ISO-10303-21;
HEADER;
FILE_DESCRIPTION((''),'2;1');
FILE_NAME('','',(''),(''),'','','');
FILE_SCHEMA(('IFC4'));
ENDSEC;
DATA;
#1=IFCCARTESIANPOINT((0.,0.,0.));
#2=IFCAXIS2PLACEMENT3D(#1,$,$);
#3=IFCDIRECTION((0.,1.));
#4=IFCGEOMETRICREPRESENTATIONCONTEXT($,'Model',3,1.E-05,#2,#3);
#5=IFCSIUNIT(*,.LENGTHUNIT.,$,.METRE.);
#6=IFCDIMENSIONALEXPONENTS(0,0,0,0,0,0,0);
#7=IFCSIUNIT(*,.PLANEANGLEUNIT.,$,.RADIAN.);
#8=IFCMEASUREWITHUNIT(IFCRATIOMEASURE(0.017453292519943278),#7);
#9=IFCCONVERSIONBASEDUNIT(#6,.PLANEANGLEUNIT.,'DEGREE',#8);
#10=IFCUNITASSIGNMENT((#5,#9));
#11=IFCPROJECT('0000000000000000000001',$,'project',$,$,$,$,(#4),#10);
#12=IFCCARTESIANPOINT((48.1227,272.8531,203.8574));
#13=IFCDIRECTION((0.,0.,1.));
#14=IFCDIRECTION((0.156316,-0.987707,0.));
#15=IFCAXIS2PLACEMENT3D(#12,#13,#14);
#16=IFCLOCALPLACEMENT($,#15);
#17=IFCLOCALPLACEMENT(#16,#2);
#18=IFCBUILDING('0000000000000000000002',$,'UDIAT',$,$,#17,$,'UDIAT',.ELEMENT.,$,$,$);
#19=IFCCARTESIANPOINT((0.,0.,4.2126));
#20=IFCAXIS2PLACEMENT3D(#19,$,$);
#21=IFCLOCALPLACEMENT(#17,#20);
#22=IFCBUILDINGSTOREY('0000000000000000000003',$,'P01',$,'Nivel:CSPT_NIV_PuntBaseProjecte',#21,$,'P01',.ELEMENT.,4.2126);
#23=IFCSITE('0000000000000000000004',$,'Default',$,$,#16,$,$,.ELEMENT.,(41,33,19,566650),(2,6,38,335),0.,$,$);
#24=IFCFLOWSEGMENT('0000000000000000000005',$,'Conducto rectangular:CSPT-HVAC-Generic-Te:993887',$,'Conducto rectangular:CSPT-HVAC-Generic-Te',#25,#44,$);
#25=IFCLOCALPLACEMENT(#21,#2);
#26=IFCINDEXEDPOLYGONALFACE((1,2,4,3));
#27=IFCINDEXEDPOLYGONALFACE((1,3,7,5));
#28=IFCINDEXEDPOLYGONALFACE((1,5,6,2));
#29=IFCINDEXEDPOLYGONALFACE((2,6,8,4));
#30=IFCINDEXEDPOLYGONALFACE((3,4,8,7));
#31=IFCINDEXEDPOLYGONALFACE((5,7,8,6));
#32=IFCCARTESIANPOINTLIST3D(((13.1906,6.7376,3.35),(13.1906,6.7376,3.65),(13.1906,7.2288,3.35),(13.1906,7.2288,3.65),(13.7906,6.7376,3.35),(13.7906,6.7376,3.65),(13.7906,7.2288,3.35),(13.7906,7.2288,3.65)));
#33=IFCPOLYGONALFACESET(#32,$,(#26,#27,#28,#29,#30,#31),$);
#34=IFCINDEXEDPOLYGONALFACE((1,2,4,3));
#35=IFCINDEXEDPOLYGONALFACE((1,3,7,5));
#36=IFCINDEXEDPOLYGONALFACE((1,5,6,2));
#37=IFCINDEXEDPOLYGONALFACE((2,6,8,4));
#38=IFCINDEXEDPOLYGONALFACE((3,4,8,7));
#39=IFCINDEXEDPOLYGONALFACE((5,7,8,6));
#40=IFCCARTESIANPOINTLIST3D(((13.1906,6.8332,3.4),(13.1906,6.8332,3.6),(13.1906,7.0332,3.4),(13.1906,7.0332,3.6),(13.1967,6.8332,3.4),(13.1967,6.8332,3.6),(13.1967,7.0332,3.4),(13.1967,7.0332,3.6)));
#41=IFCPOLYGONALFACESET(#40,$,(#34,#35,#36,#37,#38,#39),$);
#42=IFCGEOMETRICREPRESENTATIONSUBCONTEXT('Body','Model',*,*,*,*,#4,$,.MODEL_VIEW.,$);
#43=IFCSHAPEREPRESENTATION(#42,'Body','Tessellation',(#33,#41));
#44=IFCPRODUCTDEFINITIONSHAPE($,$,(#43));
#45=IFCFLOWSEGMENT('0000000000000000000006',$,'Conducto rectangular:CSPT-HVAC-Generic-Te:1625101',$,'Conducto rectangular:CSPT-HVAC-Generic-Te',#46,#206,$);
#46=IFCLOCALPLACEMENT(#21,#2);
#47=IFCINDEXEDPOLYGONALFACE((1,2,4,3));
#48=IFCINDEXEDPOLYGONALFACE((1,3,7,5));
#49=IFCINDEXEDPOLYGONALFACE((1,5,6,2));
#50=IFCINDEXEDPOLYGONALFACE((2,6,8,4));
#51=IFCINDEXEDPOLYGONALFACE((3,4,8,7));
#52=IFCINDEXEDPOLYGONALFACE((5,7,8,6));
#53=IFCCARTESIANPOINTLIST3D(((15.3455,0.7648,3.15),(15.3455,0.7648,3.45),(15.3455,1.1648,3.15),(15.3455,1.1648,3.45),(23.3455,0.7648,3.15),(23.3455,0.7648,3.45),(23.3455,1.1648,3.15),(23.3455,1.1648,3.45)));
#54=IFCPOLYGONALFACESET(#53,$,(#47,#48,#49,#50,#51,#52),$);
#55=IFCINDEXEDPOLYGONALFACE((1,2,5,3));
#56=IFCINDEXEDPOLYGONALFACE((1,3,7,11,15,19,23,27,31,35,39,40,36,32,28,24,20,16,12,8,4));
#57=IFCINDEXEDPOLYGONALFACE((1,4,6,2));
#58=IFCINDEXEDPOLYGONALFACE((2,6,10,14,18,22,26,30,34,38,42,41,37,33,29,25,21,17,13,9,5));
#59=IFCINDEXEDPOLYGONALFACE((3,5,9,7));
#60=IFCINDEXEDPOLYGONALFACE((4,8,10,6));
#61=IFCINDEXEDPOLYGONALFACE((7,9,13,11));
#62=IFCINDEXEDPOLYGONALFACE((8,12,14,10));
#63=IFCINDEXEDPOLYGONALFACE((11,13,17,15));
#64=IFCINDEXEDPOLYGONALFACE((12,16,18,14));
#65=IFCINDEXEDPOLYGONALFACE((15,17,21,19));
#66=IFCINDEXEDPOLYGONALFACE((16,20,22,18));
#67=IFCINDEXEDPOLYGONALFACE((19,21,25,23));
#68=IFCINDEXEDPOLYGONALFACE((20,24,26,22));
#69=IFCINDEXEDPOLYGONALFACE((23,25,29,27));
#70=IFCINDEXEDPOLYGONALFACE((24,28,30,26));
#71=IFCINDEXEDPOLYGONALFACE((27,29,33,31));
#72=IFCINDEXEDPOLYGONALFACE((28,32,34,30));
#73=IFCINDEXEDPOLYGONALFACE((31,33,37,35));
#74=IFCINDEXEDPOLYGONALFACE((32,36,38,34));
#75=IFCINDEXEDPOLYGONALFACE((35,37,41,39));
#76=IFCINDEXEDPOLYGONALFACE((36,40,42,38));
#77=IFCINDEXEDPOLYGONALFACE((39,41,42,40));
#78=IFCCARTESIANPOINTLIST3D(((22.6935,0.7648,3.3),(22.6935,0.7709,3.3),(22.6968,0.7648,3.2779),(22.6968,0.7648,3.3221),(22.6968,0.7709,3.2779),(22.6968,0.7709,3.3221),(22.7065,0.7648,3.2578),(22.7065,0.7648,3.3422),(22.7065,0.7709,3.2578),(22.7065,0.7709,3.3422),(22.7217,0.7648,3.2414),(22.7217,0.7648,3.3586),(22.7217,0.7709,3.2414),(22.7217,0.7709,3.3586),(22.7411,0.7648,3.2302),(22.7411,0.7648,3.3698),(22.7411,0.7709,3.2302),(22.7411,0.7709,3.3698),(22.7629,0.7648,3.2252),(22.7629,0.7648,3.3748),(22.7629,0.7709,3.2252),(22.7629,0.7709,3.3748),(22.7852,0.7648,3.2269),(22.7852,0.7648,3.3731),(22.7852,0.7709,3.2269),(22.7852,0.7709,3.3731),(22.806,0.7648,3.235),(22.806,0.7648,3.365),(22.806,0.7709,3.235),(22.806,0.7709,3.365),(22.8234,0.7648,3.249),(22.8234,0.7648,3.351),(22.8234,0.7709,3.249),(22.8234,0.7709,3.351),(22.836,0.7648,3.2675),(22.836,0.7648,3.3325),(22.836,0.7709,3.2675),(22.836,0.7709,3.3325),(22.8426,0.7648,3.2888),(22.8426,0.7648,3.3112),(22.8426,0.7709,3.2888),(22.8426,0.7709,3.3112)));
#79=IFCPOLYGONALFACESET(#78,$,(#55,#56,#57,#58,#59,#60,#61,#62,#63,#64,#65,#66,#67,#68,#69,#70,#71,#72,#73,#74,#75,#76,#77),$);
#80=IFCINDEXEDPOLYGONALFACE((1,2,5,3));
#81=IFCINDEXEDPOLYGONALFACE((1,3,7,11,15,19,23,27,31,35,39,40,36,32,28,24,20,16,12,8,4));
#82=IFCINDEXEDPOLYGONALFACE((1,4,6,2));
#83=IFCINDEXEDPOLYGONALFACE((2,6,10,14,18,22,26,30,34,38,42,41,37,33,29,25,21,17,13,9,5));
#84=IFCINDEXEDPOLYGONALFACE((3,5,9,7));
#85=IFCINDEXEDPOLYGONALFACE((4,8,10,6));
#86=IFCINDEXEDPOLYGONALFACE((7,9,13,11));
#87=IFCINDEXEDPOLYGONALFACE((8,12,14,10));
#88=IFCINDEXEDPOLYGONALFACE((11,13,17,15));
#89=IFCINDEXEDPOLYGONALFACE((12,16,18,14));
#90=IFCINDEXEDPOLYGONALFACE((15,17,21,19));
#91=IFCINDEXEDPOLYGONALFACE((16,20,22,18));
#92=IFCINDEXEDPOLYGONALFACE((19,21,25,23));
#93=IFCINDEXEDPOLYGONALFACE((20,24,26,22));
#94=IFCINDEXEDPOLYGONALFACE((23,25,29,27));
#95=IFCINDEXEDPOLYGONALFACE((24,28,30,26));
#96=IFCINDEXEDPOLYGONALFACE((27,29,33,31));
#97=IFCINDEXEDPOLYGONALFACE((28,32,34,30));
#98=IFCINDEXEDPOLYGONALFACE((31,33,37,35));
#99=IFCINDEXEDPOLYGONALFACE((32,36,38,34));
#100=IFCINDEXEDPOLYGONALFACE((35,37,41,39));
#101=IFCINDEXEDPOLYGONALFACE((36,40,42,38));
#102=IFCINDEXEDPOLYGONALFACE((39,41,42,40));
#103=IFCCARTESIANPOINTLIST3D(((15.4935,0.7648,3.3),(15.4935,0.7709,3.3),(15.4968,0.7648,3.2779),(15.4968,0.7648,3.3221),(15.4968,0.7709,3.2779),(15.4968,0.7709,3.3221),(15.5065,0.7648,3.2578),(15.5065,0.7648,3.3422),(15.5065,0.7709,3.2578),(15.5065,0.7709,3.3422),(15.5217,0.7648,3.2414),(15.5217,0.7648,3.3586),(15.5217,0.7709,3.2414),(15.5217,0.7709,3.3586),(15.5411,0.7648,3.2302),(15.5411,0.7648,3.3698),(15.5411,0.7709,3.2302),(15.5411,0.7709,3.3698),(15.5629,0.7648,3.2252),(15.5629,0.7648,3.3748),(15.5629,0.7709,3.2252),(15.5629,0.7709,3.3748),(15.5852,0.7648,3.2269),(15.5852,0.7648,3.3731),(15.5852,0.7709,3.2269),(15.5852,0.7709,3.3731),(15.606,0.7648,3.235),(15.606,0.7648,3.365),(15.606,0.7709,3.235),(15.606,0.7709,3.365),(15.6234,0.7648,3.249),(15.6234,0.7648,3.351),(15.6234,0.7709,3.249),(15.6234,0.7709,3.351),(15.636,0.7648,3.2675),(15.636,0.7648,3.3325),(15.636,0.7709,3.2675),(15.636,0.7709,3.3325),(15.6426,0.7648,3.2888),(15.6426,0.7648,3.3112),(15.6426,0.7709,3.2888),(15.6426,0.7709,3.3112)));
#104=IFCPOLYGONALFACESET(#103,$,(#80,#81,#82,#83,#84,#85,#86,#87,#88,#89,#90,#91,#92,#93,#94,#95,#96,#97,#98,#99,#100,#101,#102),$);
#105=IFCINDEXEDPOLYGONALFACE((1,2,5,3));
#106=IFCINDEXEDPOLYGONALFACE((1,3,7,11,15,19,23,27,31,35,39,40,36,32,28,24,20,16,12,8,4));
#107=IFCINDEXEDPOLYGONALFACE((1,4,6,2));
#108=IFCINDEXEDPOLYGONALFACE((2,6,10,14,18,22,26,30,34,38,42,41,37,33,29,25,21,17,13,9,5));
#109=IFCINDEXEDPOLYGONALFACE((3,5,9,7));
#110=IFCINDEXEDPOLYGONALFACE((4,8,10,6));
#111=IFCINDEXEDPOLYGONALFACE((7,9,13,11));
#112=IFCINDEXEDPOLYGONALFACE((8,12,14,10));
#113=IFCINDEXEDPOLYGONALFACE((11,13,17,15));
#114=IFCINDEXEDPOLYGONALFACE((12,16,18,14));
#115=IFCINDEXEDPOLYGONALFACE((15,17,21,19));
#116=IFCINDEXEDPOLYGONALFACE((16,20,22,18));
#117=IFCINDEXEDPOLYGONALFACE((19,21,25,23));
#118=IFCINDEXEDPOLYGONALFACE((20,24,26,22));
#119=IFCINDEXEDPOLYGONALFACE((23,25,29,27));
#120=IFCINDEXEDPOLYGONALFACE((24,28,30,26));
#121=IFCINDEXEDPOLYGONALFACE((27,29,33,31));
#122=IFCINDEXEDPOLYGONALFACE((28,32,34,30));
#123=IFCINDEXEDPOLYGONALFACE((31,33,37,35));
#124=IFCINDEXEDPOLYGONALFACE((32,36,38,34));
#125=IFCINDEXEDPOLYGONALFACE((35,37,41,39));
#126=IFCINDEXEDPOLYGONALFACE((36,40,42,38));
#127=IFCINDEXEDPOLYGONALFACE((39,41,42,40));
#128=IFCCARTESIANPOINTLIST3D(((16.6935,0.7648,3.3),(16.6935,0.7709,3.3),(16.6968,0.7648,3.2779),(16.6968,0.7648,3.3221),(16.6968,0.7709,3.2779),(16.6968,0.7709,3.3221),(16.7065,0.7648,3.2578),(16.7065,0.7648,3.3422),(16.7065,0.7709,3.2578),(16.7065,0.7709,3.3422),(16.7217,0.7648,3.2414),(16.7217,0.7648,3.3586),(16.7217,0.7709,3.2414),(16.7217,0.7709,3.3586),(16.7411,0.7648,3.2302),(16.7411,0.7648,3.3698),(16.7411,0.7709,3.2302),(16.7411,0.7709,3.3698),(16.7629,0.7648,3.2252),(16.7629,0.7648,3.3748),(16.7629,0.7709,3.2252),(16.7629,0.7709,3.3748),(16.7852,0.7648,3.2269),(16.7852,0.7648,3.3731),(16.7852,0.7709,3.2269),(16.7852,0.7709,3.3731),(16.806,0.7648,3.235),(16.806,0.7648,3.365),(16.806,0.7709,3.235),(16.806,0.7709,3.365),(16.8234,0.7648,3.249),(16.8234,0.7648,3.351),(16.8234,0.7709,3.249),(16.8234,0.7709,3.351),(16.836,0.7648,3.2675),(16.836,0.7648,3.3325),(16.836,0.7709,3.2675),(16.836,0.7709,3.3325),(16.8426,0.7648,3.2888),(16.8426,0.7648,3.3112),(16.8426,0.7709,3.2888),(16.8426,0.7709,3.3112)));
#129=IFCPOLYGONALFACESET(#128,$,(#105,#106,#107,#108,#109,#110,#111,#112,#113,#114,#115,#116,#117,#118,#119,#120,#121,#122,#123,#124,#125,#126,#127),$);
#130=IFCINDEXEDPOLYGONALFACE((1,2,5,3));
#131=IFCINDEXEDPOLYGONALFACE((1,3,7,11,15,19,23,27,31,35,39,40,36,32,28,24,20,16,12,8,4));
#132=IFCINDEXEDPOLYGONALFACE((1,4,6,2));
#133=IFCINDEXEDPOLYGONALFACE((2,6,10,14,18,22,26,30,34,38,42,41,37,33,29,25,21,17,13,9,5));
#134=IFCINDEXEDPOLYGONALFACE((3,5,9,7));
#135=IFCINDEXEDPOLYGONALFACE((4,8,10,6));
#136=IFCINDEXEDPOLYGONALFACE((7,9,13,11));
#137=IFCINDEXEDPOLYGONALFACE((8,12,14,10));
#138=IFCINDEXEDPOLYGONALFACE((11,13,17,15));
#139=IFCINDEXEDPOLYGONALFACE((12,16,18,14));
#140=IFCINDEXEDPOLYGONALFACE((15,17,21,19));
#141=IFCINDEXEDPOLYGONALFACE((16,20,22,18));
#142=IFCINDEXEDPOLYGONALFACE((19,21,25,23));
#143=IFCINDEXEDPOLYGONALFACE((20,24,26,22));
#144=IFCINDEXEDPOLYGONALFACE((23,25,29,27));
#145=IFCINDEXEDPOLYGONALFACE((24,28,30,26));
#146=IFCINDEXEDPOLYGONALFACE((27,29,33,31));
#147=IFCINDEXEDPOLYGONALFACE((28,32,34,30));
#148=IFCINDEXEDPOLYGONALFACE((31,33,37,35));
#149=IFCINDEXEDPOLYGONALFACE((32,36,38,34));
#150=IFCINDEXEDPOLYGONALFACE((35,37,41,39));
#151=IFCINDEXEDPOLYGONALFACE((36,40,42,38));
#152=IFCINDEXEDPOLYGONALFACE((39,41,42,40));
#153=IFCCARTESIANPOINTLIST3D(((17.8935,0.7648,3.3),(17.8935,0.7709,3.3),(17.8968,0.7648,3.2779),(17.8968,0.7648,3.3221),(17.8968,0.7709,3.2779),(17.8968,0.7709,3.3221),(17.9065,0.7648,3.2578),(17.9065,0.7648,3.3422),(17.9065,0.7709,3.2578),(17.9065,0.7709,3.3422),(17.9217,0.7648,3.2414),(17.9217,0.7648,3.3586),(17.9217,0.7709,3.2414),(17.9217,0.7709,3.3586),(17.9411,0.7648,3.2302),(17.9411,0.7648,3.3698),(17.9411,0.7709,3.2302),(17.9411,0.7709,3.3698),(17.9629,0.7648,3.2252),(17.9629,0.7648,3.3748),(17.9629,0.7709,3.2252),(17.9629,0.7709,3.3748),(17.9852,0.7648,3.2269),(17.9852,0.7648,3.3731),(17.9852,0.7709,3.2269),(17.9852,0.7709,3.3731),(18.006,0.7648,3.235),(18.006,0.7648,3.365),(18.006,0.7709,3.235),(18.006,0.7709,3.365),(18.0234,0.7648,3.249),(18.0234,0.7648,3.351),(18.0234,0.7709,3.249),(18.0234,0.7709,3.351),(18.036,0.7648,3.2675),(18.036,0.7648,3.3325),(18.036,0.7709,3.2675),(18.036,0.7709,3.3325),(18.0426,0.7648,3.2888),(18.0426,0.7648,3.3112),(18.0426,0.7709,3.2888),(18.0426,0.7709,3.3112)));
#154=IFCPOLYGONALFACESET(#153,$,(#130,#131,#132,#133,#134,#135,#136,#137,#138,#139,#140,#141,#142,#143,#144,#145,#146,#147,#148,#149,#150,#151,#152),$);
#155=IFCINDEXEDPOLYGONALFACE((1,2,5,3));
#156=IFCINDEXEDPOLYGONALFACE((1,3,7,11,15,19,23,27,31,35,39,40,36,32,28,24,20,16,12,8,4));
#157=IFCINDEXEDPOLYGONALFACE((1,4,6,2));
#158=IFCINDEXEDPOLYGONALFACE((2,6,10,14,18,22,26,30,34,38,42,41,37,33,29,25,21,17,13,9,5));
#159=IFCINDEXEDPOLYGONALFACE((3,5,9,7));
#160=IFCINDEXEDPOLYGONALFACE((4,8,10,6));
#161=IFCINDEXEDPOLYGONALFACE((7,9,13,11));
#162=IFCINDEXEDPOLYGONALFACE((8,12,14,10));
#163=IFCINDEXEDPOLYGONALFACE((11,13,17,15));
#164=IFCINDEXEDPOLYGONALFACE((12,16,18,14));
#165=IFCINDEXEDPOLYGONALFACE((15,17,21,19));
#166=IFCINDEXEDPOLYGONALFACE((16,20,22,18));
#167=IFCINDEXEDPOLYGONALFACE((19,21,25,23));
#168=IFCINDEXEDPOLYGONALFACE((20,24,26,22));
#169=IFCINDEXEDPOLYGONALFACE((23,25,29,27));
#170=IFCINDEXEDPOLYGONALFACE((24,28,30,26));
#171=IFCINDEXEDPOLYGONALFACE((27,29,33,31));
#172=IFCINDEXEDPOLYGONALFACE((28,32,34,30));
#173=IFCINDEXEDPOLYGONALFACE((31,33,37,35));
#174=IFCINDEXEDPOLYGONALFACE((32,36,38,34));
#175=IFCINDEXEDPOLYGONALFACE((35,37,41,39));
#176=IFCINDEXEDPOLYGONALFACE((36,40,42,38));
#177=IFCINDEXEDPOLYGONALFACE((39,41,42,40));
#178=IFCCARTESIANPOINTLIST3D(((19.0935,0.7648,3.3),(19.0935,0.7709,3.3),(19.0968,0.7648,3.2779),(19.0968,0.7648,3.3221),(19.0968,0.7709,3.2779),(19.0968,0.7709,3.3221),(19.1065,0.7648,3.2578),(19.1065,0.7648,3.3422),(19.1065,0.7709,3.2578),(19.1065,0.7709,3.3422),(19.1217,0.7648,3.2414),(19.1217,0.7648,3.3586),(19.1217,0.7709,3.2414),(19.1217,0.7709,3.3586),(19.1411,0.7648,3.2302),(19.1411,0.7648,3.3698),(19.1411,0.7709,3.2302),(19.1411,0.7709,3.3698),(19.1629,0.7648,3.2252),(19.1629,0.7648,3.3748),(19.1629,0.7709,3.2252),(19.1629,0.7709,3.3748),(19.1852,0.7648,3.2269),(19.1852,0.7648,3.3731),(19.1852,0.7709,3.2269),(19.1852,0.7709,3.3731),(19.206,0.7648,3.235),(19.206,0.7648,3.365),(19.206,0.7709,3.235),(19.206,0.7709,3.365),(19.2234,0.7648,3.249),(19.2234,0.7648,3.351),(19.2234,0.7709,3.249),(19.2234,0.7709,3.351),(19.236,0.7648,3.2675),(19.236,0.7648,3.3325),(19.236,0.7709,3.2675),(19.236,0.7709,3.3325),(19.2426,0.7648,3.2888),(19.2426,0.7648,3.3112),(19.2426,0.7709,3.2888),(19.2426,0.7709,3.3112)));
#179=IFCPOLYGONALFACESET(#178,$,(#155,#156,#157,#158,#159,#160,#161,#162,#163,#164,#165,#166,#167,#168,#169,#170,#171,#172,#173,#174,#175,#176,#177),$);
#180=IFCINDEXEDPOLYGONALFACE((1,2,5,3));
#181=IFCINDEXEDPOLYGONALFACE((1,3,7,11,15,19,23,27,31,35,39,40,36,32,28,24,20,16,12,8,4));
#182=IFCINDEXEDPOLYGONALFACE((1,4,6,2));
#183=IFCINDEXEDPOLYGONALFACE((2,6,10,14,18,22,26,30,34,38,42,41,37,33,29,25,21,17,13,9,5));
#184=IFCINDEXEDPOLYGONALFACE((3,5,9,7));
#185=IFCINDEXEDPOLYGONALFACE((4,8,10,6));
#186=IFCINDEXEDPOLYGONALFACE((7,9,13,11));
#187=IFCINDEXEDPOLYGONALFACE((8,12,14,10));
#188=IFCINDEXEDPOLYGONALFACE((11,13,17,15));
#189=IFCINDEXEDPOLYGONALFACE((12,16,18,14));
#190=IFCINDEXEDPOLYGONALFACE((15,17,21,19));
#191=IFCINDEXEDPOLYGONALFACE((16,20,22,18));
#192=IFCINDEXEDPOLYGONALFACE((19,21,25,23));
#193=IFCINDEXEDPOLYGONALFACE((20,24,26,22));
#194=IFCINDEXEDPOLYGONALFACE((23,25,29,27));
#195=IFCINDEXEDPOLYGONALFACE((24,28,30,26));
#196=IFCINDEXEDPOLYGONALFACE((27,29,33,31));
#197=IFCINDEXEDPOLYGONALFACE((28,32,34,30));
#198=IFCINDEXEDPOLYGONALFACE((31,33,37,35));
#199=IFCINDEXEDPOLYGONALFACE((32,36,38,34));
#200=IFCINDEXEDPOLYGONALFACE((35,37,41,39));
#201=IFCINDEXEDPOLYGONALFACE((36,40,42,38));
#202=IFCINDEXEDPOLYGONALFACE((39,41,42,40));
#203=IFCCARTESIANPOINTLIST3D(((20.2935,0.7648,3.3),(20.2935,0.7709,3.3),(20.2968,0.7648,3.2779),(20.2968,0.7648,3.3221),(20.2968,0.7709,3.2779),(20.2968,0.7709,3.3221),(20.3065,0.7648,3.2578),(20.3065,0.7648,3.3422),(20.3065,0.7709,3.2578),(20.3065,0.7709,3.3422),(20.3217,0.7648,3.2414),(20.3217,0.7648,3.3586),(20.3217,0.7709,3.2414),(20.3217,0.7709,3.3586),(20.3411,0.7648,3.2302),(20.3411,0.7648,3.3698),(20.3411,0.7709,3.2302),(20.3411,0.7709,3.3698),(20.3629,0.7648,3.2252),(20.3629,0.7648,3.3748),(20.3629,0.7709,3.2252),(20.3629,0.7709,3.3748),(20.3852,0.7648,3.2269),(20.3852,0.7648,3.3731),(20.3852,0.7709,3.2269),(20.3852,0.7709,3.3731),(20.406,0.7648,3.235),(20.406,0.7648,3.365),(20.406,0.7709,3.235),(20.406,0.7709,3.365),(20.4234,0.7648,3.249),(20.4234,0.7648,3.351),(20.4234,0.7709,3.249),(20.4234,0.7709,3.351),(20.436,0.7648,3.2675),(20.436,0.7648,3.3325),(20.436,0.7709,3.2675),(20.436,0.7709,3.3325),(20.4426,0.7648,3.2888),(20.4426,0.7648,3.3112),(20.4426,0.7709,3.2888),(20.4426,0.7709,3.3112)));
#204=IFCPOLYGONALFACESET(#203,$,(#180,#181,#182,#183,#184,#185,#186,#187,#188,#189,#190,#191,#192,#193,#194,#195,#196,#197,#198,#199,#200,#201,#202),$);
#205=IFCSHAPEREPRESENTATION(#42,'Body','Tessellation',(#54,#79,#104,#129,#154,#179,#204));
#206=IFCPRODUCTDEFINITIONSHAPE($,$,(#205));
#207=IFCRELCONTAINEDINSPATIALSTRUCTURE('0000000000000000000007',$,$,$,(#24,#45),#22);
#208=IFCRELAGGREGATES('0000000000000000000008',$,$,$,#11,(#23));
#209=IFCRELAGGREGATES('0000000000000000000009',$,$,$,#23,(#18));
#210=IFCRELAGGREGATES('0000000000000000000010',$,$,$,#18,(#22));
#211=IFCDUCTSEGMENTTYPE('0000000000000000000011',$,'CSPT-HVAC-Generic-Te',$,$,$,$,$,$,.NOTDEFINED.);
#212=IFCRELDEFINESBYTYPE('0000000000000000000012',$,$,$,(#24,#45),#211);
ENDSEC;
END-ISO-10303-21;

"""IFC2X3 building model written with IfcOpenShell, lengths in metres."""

from ifc_helpers import new_model, entity, si_unit, converted_unit, direction, frame, frame_2d, origin, place, context, subcontext, project, spatial, rectangle, circle, extrude, type_object, element, save


model = new_model("IFC2X3")

# Units and contexts
model_context = context("Model", 3, precision=1e-05, world=origin(), true_north=direction((0.0, 1.0)))
body_context = subcontext(model_context, "Body", "Model", "MODEL_VIEW")
ifc_project = project(units=[si_unit("LENGTHUNIT", "METRE"), converted_unit("PLANEANGLEUNIT", "DEGREE", entity("IfcRatioMeasure", 0.017453292519943278), si_unit("PLANEANGLEUNIT", "RADIAN"), dimensions=[0, 0, 0, 0, 0, 0, 0])], contexts=[model_context])

# Site, building, storey
site_placement = place(None, frame((48.1227, 272.8531, 203.8574), z_axis=(0.0, 0.0, 1.0), x_axis=(0.156316, -0.987707, 0.0)))
site = spatial("IfcSite", under=ifc_project, at=site_placement, Name="Default", CompositionType="ELEMENT", RefLatitude=(41, 33, 19, 566650), RefLongitude=(2, 6, 38, 335), RefElevation=0.0)
building_placement = place(site_placement, origin())
building = spatial("IfcBuilding", under=site, at=building_placement, Name="UDIAT", LongName="UDIAT", CompositionType="ELEMENT")
storey_placement = place(building_placement, frame((0.0, 0.0, 4.2126)))
storey = spatial("IfcBuildingStorey", under=building, at=storey_placement, Name="P01", ObjectType="Nivel:CSPT_NIV_PuntBaseProjecte", LongName="P01", CompositionType="ELEMENT", Elevation=4.2126)

# Flow segments
duct_segment_type = type_object("IfcDuctSegmentType", Name="CSPT-HVAC-Generic-Te", PredefinedType="NOTDEFINED")
flow_segment_1_placement = place(storey_placement, origin())
element("IfcFlowSegment", 1, at=flow_segment_1_placement, inside=storey, type_object=duct_segment_type, Name="Conducto rectangular:CSPT-HVAC-Generic-Te:993887", ObjectType="Conducto rectangular:CSPT-HVAC-Generic-Te", context=body_context, shape_type="SweptSolid", body=[
    extrude(rectangle(XDim=0.4912, YDim=0.6, at=frame_2d((0.0, 0.0), x_axis=(1.0, 0.0))), frame((13.4906, 6.9832, 3.35), z_axis=(0.0, 0.0, 1.0), x_axis=(0.0, -1.0, 0.0)), (0.0, 0.0, 1.0), 0.3),
    extrude(rectangle(XDim=0.0061, YDim=0.2, at=frame_2d((0.0, 0.0), x_axis=(1.0, 0.0))), frame((13.1936, 6.9332, 3.4), z_axis=(0.0, 0.0, 1.0), x_axis=(-1.0, 0.0, 0.0)), (0.0, 0.0, 1.0), 0.2),
])
flow_segment_2_placement = place(storey_placement, origin())
element("IfcFlowSegment", 2, at=flow_segment_2_placement, inside=storey, type_object=duct_segment_type, Name="Conducto rectangular:CSPT-HVAC-Generic-Te:1625101", ObjectType="Conducto rectangular:CSPT-HVAC-Generic-Te", context=body_context, shape_type="SweptSolid", body=[
    extrude(rectangle(XDim=8.0, YDim=0.4, at=frame_2d((0.0, 0.0), x_axis=(1.0, 0.0))), frame((19.3455, 0.9648, 3.15)), (0.0, 0.0, 1.0), 0.3),
    extrude(circle(Radius=0.075, at=frame_2d((0.0, 0.0), x_axis=(1.0, 0.0))), frame((22.7685, 0.7648, 3.3), z_axis=(0.0, 1.0, 0.0), x_axis=(-1.0, 0.0, 0.0)), (0.0, 0.0, 1.0), 0.0061),
    extrude(circle(Radius=0.075, at=frame_2d((0.0, 0.0), x_axis=(1.0, 0.0))), frame((15.5685, 0.7648, 3.3), z_axis=(0.0, 1.0, 0.0), x_axis=(-1.0, 0.0, 0.0)), (0.0, 0.0, 1.0), 0.0061),
    extrude(circle(Radius=0.075, at=frame_2d((0.0, 0.0), x_axis=(1.0, 0.0))), frame((16.7685, 0.7648, 3.3), z_axis=(0.0, 1.0, 0.0), x_axis=(-1.0, 0.0, 0.0)), (0.0, 0.0, 1.0), 0.0061),
    extrude(circle(Radius=0.075, at=frame_2d((0.0, 0.0), x_axis=(1.0, 0.0))), frame((17.9685, 0.7648, 3.3), z_axis=(0.0, 1.0, 0.0), x_axis=(-1.0, 0.0, 0.0)), (0.0, 0.0, 1.0), 0.0061),
    extrude(circle(Radius=0.075, at=frame_2d((0.0, 0.0), x_axis=(1.0, 0.0))), frame((19.1685, 0.7648, 3.3), z_axis=(0.0, 1.0, 0.0), x_axis=(-1.0, 0.0, 0.0)), (0.0, 0.0, 1.0), 0.0061),
    extrude(circle(Radius=0.075, at=frame_2d((0.0, 0.0), x_axis=(1.0, 0.0))), frame((20.3685, 0.7648, 3.3), z_axis=(0.0, 1.0, 0.0), x_axis=(-1.0, 0.0, 0.0)), (0.0, 0.0, 1.0), 0.0061),
])

save(model, "model.ifc")
